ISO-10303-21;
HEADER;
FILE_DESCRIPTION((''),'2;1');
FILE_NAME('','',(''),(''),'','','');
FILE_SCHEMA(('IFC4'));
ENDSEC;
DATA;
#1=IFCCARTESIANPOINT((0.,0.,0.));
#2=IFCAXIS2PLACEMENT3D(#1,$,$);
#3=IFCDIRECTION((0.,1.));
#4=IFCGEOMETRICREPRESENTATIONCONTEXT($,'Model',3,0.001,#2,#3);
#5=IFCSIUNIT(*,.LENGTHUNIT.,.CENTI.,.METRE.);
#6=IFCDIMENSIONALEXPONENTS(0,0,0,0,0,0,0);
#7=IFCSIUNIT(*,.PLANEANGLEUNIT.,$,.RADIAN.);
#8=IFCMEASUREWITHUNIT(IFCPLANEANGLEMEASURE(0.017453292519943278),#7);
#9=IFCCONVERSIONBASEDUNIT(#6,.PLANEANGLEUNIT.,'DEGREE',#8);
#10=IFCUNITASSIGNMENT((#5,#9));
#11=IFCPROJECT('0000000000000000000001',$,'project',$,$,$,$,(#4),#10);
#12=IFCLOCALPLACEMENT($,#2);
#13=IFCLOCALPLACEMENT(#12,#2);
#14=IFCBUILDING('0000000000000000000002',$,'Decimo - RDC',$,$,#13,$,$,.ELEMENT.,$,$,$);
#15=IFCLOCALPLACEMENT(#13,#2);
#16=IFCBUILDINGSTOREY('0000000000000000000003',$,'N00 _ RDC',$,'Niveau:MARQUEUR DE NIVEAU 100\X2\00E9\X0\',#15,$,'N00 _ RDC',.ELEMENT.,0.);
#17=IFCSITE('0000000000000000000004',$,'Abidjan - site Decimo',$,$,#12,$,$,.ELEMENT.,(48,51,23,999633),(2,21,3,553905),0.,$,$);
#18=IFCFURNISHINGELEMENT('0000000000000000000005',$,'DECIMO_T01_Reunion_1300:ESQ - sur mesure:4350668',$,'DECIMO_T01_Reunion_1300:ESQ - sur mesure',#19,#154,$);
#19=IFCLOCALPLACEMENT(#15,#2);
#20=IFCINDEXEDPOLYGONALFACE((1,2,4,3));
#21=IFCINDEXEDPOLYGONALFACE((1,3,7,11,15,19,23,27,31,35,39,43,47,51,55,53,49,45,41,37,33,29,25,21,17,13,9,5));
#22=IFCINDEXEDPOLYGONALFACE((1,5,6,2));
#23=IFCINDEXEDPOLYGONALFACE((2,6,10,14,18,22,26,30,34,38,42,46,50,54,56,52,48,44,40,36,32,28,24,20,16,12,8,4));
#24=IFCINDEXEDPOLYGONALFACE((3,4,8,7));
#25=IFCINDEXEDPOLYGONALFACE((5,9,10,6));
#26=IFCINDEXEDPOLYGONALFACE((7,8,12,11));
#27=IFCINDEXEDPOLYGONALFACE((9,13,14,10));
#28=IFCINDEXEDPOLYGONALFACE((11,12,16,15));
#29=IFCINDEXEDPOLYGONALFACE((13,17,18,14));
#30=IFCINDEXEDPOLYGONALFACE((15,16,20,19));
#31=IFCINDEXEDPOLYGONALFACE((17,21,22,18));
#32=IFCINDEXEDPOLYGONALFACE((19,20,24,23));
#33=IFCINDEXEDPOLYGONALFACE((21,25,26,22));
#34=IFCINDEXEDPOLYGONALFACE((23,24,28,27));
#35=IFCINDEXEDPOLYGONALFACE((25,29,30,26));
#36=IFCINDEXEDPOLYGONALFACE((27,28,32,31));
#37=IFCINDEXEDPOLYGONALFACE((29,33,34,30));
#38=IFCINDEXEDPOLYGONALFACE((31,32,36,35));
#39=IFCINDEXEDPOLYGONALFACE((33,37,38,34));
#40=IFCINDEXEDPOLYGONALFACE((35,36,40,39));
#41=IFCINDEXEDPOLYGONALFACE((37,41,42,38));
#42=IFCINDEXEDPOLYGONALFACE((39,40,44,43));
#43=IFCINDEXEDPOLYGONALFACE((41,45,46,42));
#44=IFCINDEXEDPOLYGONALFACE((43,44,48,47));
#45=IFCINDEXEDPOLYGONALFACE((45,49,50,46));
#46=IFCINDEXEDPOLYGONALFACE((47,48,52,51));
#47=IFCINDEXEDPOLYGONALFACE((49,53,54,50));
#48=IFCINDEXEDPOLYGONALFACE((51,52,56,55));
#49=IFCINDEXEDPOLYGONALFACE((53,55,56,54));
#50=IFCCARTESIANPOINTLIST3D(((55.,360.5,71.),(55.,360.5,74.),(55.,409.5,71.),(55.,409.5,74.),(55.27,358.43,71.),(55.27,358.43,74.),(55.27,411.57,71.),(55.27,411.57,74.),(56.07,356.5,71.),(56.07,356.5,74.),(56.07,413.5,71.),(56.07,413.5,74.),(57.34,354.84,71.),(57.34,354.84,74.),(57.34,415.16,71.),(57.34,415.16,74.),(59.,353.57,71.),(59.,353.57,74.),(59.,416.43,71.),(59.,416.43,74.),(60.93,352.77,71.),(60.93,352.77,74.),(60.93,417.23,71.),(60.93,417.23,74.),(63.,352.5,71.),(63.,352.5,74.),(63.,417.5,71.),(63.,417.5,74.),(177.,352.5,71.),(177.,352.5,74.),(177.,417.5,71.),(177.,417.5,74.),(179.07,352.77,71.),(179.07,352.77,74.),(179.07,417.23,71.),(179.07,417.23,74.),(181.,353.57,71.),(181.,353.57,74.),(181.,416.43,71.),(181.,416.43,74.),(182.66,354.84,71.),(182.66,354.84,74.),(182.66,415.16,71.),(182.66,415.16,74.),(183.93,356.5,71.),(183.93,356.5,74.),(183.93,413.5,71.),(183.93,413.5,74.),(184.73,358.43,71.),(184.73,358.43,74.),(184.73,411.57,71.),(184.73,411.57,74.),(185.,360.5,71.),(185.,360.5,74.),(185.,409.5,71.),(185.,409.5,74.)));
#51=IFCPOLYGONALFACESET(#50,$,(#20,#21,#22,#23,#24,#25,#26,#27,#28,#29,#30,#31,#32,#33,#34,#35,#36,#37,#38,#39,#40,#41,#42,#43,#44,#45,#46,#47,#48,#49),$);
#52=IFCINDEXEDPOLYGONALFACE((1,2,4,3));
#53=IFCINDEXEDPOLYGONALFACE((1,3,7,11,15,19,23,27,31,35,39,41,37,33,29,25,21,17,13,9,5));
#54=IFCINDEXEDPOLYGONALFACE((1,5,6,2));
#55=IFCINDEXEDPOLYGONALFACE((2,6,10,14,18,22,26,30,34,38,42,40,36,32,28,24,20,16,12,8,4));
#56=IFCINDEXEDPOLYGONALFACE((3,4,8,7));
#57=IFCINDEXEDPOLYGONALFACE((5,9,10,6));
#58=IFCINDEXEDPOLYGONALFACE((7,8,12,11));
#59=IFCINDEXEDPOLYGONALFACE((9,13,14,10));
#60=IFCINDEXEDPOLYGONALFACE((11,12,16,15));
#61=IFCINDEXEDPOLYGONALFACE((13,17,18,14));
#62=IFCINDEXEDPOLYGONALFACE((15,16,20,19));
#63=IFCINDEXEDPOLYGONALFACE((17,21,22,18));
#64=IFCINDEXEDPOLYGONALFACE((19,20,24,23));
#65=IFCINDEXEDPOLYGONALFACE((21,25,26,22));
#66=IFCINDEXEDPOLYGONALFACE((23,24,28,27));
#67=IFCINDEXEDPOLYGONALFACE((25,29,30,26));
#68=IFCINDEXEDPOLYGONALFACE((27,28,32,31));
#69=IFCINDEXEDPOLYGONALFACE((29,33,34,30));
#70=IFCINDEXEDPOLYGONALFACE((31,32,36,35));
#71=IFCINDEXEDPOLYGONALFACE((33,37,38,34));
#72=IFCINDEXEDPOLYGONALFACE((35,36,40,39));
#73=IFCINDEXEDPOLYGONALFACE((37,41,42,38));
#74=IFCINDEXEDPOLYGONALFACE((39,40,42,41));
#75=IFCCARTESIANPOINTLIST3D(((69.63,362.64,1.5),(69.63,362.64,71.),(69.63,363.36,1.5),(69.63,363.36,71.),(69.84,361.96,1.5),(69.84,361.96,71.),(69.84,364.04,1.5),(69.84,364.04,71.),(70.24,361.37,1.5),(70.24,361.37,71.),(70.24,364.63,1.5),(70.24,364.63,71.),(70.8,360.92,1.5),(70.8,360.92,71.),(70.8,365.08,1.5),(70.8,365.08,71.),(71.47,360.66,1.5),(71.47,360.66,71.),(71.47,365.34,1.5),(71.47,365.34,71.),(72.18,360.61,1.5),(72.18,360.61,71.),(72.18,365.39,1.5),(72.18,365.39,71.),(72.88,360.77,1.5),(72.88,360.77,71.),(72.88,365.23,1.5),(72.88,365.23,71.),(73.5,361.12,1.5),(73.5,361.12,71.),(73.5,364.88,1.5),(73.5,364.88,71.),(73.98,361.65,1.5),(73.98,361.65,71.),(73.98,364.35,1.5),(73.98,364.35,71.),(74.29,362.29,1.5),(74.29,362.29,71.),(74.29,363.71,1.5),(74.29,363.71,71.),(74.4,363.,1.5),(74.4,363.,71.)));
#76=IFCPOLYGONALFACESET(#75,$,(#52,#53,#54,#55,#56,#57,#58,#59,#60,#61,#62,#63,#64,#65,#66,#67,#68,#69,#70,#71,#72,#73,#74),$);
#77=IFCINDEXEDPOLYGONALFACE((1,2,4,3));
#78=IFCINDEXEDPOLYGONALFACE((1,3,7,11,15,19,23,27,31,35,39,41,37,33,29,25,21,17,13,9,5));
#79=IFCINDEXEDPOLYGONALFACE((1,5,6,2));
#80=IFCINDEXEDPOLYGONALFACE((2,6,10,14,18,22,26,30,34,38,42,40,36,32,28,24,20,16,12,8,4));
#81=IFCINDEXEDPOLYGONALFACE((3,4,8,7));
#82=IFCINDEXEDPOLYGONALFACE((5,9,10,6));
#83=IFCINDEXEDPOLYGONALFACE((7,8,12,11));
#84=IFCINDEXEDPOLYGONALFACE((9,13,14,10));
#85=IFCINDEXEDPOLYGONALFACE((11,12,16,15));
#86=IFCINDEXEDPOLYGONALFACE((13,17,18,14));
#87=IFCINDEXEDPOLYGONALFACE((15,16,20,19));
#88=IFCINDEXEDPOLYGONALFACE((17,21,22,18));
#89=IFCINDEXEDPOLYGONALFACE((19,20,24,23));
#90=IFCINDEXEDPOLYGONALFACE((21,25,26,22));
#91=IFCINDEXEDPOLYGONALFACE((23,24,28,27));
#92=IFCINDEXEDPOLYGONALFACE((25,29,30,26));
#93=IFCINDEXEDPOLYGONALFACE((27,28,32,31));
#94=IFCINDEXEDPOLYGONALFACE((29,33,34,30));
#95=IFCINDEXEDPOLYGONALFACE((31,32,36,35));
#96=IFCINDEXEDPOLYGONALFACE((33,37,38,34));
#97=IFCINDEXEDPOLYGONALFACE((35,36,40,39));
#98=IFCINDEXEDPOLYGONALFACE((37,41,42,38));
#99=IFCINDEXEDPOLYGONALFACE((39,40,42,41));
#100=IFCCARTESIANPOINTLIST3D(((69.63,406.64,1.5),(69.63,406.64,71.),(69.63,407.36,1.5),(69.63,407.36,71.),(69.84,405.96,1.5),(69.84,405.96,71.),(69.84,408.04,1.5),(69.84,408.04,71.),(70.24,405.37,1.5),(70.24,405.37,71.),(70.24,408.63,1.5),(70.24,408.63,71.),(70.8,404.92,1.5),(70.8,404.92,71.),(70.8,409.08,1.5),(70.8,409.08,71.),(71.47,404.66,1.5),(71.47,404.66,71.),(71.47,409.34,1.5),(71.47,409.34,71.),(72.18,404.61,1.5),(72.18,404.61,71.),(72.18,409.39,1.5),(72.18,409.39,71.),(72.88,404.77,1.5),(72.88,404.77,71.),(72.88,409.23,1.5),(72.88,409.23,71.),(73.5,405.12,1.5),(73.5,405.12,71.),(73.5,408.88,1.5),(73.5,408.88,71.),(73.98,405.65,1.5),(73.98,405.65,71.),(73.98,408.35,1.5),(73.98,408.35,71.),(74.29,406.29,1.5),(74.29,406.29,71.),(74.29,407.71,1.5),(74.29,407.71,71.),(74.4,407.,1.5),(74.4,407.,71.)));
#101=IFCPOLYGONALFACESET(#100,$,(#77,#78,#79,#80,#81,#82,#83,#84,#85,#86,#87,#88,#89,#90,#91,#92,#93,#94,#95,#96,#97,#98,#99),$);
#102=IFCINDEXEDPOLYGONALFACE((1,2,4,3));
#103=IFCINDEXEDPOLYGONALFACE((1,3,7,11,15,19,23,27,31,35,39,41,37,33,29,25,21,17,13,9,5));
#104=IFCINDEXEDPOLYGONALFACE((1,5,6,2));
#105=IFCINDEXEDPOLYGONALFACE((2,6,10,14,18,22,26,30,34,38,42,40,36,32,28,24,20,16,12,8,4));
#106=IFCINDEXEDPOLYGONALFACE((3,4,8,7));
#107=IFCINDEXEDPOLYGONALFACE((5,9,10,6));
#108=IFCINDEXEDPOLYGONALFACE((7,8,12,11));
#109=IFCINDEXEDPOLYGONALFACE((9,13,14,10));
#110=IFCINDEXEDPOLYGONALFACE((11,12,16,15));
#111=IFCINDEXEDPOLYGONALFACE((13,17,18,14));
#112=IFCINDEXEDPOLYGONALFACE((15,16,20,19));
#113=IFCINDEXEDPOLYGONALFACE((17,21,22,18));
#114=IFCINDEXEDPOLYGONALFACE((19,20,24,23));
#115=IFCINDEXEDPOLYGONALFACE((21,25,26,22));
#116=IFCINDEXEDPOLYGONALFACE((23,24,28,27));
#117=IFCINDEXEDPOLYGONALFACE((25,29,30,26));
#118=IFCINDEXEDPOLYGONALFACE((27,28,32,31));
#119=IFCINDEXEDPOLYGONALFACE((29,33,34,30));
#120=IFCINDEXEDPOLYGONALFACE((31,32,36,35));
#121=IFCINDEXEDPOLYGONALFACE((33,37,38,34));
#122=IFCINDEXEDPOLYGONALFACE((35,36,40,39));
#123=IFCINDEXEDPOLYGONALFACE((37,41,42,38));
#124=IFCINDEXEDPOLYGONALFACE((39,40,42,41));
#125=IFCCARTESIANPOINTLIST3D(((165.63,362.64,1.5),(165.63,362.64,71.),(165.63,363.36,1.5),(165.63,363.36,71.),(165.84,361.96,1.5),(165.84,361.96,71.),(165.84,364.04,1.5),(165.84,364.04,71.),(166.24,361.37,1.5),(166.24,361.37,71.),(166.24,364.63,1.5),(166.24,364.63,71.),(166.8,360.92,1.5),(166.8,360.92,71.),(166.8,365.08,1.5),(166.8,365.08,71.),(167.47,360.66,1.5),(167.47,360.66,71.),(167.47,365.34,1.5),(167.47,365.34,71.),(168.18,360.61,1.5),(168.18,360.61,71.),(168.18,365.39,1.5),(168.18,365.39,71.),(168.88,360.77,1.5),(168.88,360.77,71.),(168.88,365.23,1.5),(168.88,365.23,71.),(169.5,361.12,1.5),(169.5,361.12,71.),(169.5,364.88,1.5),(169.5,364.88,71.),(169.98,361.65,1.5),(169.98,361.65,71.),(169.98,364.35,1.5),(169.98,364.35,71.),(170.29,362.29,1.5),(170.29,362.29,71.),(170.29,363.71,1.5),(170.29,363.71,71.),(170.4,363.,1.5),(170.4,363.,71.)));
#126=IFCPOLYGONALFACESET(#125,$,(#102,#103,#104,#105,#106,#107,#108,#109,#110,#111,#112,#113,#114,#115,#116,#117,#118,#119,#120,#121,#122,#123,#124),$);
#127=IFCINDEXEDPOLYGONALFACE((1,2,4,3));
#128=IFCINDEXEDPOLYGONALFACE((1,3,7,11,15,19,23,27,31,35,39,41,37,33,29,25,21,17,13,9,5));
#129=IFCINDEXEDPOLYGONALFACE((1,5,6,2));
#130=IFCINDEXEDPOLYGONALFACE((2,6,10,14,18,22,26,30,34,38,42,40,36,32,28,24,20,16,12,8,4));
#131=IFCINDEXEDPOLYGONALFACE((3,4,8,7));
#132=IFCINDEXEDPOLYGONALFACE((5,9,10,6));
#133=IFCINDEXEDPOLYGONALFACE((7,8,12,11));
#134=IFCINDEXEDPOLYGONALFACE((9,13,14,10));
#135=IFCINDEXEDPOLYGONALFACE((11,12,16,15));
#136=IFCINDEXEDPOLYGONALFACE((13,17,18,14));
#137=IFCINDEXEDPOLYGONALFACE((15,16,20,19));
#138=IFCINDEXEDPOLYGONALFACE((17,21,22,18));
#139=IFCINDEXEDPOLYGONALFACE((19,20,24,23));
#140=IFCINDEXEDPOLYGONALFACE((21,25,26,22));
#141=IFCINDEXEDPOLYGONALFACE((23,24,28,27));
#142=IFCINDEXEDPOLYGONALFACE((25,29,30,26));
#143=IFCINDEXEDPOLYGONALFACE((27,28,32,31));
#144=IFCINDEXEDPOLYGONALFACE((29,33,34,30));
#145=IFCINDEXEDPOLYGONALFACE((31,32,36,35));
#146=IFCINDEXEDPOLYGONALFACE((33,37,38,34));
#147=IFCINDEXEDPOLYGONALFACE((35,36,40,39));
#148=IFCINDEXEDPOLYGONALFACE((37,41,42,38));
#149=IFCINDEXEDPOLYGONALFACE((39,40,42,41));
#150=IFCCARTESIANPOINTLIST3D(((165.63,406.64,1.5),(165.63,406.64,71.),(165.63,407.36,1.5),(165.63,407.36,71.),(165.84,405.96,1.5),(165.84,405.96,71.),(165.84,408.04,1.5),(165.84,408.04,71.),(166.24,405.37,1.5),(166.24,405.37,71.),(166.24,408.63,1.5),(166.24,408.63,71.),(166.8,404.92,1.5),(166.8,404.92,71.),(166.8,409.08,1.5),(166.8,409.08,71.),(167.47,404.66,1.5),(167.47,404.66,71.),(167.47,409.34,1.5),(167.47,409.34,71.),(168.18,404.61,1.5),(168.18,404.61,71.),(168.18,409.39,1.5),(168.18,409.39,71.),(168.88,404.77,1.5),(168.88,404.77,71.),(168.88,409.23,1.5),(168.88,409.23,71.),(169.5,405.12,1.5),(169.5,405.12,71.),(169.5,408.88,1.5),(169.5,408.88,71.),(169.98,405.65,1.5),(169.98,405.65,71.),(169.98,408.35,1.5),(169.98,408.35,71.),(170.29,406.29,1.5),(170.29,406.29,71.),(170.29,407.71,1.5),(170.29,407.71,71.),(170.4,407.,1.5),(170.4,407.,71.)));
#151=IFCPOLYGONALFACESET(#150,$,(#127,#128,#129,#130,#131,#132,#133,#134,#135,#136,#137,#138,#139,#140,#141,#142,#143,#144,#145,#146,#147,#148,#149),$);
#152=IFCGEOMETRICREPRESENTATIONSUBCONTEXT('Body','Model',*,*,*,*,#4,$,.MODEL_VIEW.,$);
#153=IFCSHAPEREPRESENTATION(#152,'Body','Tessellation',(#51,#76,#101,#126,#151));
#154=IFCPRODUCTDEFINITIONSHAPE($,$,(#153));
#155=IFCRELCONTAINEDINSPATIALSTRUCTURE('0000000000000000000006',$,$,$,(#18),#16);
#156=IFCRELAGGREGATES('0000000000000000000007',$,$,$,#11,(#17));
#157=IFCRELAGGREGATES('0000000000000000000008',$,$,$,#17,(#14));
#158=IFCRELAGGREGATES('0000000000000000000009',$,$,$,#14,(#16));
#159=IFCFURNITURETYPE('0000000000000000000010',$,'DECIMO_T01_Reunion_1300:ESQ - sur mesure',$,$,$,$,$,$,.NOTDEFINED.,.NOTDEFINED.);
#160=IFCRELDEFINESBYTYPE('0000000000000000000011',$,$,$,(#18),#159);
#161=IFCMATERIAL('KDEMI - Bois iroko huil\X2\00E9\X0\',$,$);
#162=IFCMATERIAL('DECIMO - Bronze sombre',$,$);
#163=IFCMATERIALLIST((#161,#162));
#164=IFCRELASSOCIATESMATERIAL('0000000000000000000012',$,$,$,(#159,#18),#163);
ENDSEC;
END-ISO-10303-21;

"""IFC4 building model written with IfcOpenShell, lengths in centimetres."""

from ifc_helpers import new_model, entity, si_unit, converted_unit, direction, frame, frame_2d, origin, origin_2d_with_axis, place, context, subcontext, project, spatial, polyline, circle_curve, parameter, trimmed, segment, composite_curve, circle, outline, extrude, source, transform, mapped, material, material_list, type_object, type_shapes, element, save


model = new_model("IFC4")

# Units and contexts
model_context = context("Model", 3, precision=0.001, world=origin(), true_north=direction((0.0, 1.0)))
body_context = subcontext(model_context, "Body", "Model", "MODEL_VIEW")
ifc_project = project(units=[si_unit("LENGTHUNIT", "METRE", prefix="CENTI"), converted_unit("PLANEANGLEUNIT", "DEGREE", entity("IfcPlaneAngleMeasure", 0.017453292519943278), si_unit("PLANEANGLEUNIT", "RADIAN"), dimensions=[0, 0, 0, 0, 0, 0, 0])], contexts=[model_context])

# Site, building, storey
site_placement = place(None, origin())
site = spatial("IfcSite", under=ifc_project, at=site_placement, Name="Abidjan - site Decimo", CompositionType="ELEMENT", RefLatitude=(48, 51, 23, 999633), RefLongitude=(2, 21, 3, 553905), RefElevation=0.0)
building_placement = place(site_placement, origin())
building = spatial("IfcBuilding", under=site, at=building_placement, Name="Decimo - RDC", CompositionType="ELEMENT")
storey_placement = place(building_placement, origin())
storey = spatial("IfcBuildingStorey", under=building, at=storey_placement, Name="N00 _ RDC", ObjectType="Niveau:MARQUEUR DE NIVEAU 100é", LongName="N00 _ RDC", CompositionType="ELEMENT", Elevation=0.0)

# Furnishing element
ifc_material_1 = material(Name="KDEMI - Bois iroko huilé")
ifc_material_2 = material(Name="DECIMO - Bronze sombre")
ifc_material_list_1 = material_list([ifc_material_1, ifc_material_2])
furniture_type_1 = type_object("IfcFurnitureType", Name="DECIMO_T01_Reunion_1300:ESQ - sur mesure", AssemblyPlace="NOTDEFINED", material=ifc_material_list_1)
shared_shape_1 = source(origin(), body_context, "Body", "SweptSolid", [
    extrude(outline(composite_curve([segment(polyline([(-57.0, -32.5), (57.0, -32.5)]), True, "CONTINUOUS"), segment(trimmed(circle_curve(frame_2d((57.0, -24.5), x_axis=(1.0, 0.0)), 8.0), [parameter(270.0)], [parameter(0.0)], True, "PARAMETER"), True, "CONTINUOUS"), segment(polyline([(65.0, -24.5), (65.0, 24.5)]), True, "CONTINUOUS"), segment(trimmed(circle_curve(frame_2d((57.0, 24.5), x_axis=(1.0, 0.0)), 8.0), [parameter(0.0)], [parameter(90.0)], True, "PARAMETER"), True, "CONTINUOUS"), segment(polyline([(57.0, 32.5), (-57.0, 32.5)]), True, "CONTINUOUS"), segment(trimmed(circle_curve(frame_2d((-57.0, 24.5), x_axis=(1.0, 0.0)), 8.0), [parameter(90.0)], [parameter(180.0)], True, "PARAMETER"), True, "CONTINUOUS"), segment(polyline([(-65.0, 24.5), (-65.0, -24.5)]), True, "CONTINUOUS"), segment(trimmed(circle_curve(frame_2d((-57.0, -24.5), x_axis=(1.0, 0.0)), 8.0), [parameter(180.0)], [parameter(270.0)], True, "PARAMETER"), True, "CONTINUOUS")], self_intersect=False)), frame((0.0, 0.0, 71.0)), (0.0, 0.0, 1.0), 3.0),
    extrude(circle(Radius=2.4, at=origin_2d_with_axis()), frame((-48.0, -22.0, 1.5)), (0.0, 0.0, 1.0), 69.5),
    extrude(circle(Radius=2.4, at=origin_2d_with_axis()), frame((-48.0, 22.0, 1.5)), (0.0, 0.0, 1.0), 69.5),
    extrude(circle(Radius=2.4, at=origin_2d_with_axis()), frame((48.0, -22.0, 1.5)), (0.0, 0.0, 1.0), 69.5),
    extrude(circle(Radius=2.4, at=origin_2d_with_axis()), frame((48.0, 22.0, 1.5)), (0.0, 0.0, 1.0), 69.5),
])
type_shapes(furniture_type_1, [shared_shape_1])
furnishing_1_placement = place(storey_placement, frame((120.0, 385.0, 0.0)))
element("IfcFurnishingElement", 1, at=furnishing_1_placement, inside=storey, type_object=furniture_type_1, material=ifc_material_list_1, Name="DECIMO_T01_Reunion_1300:ESQ - sur mesure:4350668", ObjectType="DECIMO_T01_Reunion_1300:ESQ - sur mesure", context=body_context, shape_type="MappedRepresentation", body=[
    mapped(shared_shape_1, transform((0.0, 0.0, 0.0), scale=1.0)),
])

save(model, "model.ifc")
